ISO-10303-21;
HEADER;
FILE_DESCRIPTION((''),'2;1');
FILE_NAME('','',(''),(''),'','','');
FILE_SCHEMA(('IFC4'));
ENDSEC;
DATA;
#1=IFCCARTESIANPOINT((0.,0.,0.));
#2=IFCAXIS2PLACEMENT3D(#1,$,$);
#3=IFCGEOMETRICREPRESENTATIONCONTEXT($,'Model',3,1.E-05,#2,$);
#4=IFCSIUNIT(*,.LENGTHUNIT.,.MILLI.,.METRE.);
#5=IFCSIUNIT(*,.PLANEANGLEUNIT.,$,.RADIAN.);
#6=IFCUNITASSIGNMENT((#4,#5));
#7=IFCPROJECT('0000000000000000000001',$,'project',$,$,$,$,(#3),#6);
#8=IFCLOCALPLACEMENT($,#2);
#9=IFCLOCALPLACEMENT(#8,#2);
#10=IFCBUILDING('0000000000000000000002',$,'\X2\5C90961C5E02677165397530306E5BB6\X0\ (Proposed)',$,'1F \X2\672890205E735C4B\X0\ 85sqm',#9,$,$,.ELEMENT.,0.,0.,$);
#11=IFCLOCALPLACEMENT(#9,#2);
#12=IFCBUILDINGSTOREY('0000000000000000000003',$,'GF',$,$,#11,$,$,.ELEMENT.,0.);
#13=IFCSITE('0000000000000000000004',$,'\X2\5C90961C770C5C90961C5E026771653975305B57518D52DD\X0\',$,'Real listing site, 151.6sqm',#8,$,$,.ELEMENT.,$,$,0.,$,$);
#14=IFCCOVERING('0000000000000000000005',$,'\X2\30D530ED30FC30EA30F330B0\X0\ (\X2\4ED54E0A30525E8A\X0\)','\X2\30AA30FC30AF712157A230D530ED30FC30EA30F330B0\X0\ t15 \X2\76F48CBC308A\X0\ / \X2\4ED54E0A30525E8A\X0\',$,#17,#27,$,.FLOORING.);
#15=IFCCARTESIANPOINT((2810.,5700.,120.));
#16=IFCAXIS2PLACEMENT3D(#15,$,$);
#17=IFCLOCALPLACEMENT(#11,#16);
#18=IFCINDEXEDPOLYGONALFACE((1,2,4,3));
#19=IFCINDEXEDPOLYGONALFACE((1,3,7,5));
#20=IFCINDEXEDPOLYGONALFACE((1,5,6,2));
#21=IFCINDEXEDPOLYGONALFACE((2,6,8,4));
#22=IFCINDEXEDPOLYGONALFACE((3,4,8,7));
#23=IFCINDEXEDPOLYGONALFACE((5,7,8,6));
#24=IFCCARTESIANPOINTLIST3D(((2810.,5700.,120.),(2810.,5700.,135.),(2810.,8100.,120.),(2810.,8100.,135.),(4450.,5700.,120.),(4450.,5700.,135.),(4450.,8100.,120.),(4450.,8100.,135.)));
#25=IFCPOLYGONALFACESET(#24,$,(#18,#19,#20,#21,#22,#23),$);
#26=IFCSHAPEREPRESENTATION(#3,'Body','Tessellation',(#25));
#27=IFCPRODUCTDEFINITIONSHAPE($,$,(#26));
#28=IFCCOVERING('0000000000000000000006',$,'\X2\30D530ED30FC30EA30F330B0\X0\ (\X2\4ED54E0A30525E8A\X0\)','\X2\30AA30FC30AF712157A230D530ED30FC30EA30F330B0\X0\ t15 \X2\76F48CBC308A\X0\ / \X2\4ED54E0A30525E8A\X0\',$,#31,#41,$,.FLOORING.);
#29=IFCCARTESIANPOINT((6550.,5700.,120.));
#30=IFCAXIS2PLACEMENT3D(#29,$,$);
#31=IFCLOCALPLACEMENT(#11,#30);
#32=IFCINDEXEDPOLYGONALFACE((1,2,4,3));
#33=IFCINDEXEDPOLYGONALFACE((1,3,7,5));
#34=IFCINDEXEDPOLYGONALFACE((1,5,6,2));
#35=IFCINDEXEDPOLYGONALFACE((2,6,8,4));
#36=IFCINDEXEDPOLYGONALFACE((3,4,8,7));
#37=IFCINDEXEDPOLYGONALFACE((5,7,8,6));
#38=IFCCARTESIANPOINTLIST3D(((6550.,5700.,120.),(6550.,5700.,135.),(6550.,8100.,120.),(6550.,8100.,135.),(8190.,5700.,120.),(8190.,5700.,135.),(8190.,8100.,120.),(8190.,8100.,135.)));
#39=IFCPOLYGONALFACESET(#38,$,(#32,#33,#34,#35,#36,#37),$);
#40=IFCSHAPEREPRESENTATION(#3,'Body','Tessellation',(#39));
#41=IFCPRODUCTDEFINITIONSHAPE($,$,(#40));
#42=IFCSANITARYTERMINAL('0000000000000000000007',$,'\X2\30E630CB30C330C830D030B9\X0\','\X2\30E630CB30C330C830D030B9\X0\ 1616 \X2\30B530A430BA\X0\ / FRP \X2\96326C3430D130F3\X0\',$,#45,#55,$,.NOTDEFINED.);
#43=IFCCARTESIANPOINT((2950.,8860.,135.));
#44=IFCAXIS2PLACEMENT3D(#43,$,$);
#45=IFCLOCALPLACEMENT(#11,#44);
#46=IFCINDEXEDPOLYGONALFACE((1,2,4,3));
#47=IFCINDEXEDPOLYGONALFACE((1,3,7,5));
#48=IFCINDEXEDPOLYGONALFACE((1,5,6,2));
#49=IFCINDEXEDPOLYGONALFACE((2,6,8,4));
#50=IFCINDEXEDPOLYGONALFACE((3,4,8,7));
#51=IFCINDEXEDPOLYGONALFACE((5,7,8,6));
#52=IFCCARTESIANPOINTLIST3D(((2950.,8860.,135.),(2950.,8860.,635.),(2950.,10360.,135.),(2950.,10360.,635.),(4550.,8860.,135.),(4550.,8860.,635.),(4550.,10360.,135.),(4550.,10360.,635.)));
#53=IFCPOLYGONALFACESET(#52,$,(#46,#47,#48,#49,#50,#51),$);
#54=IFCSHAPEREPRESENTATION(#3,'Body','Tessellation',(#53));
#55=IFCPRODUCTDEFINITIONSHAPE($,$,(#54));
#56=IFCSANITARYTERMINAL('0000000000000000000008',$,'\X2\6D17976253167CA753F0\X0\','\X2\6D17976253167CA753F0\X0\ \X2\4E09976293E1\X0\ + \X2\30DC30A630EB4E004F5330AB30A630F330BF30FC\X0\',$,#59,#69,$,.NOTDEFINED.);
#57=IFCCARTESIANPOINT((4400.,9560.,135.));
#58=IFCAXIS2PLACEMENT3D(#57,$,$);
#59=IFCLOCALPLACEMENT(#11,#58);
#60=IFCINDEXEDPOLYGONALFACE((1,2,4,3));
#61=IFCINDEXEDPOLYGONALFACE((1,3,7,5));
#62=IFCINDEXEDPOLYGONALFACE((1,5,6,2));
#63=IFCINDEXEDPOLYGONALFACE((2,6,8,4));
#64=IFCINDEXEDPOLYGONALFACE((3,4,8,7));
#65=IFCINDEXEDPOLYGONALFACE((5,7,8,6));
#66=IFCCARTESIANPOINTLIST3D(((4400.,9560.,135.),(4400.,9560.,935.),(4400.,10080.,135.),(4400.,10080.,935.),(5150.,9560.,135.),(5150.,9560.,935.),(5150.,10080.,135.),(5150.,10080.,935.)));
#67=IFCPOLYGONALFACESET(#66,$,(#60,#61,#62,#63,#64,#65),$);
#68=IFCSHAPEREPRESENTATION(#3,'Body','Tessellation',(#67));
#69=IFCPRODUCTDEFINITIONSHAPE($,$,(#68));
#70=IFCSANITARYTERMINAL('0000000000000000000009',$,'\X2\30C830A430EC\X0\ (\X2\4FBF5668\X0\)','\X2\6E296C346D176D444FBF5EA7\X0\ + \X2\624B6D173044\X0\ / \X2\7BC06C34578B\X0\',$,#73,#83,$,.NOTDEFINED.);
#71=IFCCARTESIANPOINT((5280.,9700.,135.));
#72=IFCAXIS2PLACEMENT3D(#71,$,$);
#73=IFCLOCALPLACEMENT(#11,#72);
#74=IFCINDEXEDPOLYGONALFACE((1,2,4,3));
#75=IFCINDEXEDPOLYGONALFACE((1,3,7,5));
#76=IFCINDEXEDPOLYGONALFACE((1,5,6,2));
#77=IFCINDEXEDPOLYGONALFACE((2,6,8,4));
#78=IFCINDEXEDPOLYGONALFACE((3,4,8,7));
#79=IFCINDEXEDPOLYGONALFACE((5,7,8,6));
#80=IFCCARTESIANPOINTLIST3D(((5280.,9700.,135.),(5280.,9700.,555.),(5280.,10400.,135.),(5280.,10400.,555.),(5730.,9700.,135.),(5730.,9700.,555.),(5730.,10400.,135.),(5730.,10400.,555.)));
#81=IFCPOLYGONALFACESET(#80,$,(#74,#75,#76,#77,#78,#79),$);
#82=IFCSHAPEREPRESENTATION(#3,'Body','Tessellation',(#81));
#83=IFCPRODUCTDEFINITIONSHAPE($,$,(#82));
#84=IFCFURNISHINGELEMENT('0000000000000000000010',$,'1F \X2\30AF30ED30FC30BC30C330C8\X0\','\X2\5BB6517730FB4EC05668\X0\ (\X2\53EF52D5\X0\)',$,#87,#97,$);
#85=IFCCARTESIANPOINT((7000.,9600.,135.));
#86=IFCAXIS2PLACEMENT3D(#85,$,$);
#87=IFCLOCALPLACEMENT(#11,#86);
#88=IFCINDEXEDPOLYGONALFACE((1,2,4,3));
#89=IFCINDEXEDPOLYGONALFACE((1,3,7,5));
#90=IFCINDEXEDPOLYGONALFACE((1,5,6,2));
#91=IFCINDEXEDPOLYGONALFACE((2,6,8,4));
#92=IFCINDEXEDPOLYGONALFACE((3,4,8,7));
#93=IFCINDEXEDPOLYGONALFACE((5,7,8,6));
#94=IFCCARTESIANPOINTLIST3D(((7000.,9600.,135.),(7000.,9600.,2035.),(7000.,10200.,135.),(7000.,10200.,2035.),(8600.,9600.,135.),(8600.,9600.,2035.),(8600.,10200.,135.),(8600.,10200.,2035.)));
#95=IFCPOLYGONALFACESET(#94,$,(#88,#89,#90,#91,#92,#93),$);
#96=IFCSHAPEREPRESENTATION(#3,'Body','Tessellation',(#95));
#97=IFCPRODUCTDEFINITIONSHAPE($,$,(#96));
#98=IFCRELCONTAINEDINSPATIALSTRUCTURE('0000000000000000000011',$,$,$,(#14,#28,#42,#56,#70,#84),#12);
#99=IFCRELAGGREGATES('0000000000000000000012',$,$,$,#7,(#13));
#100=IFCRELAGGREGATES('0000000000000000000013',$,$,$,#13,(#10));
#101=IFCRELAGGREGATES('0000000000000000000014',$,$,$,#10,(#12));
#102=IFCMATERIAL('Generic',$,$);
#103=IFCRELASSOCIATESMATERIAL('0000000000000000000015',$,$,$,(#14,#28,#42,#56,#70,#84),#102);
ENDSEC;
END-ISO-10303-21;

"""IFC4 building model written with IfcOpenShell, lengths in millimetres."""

from ifc_helpers import new_model, si_unit, frame, frame_2d, origin, place, context, project, spatial, rectangle, extrude, material, element, save


model = new_model("IFC4")

# Units and contexts
model_context = context("Model", 3, precision=1e-05, world=origin())
ifc_project = project(units=[si_unit("LENGTHUNIT", "METRE", prefix="MILLI"), si_unit("PLANEANGLEUNIT", "RADIAN")], contexts=[model_context])

# Site, building, storey
site_placement = place(None, origin())
site = spatial("IfcSite", under=ifc_project, at=site_placement, Name="岐阜県岐阜市東改田字再勝", ObjectType="Real listing site, 151.6sqm", CompositionType="ELEMENT", RefElevation=0.0)
building_placement = place(site_placement, origin())
building = spatial("IfcBuilding", under=site, at=building_placement, Name="岐阜市東改田の家 (Proposed)", ObjectType="1F 木造平屋 85sqm", CompositionType="ELEMENT", ElevationOfRefHeight=0.0, ElevationOfTerrain=0.0)
storey_placement = place(building_placement, origin())
storey = spatial("IfcBuildingStorey", under=building, at=storey_placement, Name="GF", CompositionType="ELEMENT", Elevation=0.0)

# Coverings
ifc_material_1 = material(Name="Generic")
covering_1_placement = place(storey_placement, frame((2810.0, 5700.0, 120.0)))
element("IfcCovering", 1, at=covering_1_placement, inside=storey, material=ifc_material_1, Name="フローリング (仕上げ床)", Description="オーク無垢フローリング t15 直貼り / 仕上げ床", PredefinedType="FLOORING", context=model_context, shape_type="SweptSolid", body=[
    extrude(rectangle(XDim=1640.0, YDim=2400.0, at=frame_2d((820.0, 1200.0))), frame((2810.0, 5700.0, 120.0)), (0.0, 0.0, 1.0), 15.0),
])
covering_2_placement = place(storey_placement, frame((6550.0, 5700.0, 120.0)))
element("IfcCovering", 2, at=covering_2_placement, inside=storey, material=ifc_material_1, Name="フローリング (仕上げ床)", Description="オーク無垢フローリング t15 直貼り / 仕上げ床", PredefinedType="FLOORING", context=model_context, shape_type="SweptSolid", body=[
    extrude(rectangle(XDim=1640.0, YDim=2400.0, at=frame_2d((820.0, 1200.0))), frame((6550.0, 5700.0, 120.0)), (0.0, 0.0, 1.0), 15.0),
])

# Sanitary terminals
sanitary_terminal_1_placement = place(storey_placement, frame((2950.0, 8860.0, 135.0)))
element("IfcSanitaryTerminal", 3, at=sanitary_terminal_1_placement, inside=storey, material=ifc_material_1, Name="ユニットバス", Description="ユニットバス 1616 サイズ / FRP 防水パン", PredefinedType="NOTDEFINED", context=model_context, shape_type="SweptSolid", body=[
    extrude(rectangle(XDim=1600.0, YDim=1500.0, at=frame_2d((800.0, 750.0))), frame((2950.0, 8860.0, 135.0)), (0.0, 0.0, 1.0), 500.0),
])
sanitary_terminal_2_placement = place(storey_placement, frame((4400.0, 9560.0, 135.0)))
element("IfcSanitaryTerminal", 4, at=sanitary_terminal_2_placement, inside=storey, material=ifc_material_1, Name="洗面化粧台", Description="洗面化粧台 三面鏡 + ボウル一体カウンター", PredefinedType="NOTDEFINED", context=model_context, shape_type="SweptSolid", body=[
    extrude(rectangle(XDim=750.0, YDim=520.0, at=frame_2d((375.0, 260.0))), frame((4400.0, 9560.0, 135.0)), (0.0, 0.0, 1.0), 800.0),
])
sanitary_terminal_3_placement = place(storey_placement, frame((5280.0, 9700.0, 135.0)))
element("IfcSanitaryTerminal", 5, at=sanitary_terminal_3_placement, inside=storey, material=ifc_material_1, Name="トイレ (便器)", Description="温水洗浄便座 + 手洗い / 節水型", PredefinedType="NOTDEFINED", context=model_context, shape_type="SweptSolid", body=[
    extrude(rectangle(XDim=450.0, YDim=700.0, at=frame_2d((225.0, 350.0))), frame((5280.0, 9700.0, 135.0)), (0.0, 0.0, 1.0), 420.0),
])

# Furnishing element
furnishing_placement = place(storey_placement, frame((7000.0, 9600.0, 135.0)))
element("IfcFurnishingElement", 6, at=furnishing_placement, inside=storey, material=ifc_material_1, Name="1F クローゼット", Description="家具・什器 (可動)", context=model_context, shape_type="SweptSolid", body=[
    extrude(rectangle(XDim=1600.0, YDim=600.0, at=frame_2d((800.0, 300.0))), frame((7000.0, 9600.0, 135.0)), (0.0, 0.0, 1.0), 1900.0),
])

save(model, "model.ifc")
